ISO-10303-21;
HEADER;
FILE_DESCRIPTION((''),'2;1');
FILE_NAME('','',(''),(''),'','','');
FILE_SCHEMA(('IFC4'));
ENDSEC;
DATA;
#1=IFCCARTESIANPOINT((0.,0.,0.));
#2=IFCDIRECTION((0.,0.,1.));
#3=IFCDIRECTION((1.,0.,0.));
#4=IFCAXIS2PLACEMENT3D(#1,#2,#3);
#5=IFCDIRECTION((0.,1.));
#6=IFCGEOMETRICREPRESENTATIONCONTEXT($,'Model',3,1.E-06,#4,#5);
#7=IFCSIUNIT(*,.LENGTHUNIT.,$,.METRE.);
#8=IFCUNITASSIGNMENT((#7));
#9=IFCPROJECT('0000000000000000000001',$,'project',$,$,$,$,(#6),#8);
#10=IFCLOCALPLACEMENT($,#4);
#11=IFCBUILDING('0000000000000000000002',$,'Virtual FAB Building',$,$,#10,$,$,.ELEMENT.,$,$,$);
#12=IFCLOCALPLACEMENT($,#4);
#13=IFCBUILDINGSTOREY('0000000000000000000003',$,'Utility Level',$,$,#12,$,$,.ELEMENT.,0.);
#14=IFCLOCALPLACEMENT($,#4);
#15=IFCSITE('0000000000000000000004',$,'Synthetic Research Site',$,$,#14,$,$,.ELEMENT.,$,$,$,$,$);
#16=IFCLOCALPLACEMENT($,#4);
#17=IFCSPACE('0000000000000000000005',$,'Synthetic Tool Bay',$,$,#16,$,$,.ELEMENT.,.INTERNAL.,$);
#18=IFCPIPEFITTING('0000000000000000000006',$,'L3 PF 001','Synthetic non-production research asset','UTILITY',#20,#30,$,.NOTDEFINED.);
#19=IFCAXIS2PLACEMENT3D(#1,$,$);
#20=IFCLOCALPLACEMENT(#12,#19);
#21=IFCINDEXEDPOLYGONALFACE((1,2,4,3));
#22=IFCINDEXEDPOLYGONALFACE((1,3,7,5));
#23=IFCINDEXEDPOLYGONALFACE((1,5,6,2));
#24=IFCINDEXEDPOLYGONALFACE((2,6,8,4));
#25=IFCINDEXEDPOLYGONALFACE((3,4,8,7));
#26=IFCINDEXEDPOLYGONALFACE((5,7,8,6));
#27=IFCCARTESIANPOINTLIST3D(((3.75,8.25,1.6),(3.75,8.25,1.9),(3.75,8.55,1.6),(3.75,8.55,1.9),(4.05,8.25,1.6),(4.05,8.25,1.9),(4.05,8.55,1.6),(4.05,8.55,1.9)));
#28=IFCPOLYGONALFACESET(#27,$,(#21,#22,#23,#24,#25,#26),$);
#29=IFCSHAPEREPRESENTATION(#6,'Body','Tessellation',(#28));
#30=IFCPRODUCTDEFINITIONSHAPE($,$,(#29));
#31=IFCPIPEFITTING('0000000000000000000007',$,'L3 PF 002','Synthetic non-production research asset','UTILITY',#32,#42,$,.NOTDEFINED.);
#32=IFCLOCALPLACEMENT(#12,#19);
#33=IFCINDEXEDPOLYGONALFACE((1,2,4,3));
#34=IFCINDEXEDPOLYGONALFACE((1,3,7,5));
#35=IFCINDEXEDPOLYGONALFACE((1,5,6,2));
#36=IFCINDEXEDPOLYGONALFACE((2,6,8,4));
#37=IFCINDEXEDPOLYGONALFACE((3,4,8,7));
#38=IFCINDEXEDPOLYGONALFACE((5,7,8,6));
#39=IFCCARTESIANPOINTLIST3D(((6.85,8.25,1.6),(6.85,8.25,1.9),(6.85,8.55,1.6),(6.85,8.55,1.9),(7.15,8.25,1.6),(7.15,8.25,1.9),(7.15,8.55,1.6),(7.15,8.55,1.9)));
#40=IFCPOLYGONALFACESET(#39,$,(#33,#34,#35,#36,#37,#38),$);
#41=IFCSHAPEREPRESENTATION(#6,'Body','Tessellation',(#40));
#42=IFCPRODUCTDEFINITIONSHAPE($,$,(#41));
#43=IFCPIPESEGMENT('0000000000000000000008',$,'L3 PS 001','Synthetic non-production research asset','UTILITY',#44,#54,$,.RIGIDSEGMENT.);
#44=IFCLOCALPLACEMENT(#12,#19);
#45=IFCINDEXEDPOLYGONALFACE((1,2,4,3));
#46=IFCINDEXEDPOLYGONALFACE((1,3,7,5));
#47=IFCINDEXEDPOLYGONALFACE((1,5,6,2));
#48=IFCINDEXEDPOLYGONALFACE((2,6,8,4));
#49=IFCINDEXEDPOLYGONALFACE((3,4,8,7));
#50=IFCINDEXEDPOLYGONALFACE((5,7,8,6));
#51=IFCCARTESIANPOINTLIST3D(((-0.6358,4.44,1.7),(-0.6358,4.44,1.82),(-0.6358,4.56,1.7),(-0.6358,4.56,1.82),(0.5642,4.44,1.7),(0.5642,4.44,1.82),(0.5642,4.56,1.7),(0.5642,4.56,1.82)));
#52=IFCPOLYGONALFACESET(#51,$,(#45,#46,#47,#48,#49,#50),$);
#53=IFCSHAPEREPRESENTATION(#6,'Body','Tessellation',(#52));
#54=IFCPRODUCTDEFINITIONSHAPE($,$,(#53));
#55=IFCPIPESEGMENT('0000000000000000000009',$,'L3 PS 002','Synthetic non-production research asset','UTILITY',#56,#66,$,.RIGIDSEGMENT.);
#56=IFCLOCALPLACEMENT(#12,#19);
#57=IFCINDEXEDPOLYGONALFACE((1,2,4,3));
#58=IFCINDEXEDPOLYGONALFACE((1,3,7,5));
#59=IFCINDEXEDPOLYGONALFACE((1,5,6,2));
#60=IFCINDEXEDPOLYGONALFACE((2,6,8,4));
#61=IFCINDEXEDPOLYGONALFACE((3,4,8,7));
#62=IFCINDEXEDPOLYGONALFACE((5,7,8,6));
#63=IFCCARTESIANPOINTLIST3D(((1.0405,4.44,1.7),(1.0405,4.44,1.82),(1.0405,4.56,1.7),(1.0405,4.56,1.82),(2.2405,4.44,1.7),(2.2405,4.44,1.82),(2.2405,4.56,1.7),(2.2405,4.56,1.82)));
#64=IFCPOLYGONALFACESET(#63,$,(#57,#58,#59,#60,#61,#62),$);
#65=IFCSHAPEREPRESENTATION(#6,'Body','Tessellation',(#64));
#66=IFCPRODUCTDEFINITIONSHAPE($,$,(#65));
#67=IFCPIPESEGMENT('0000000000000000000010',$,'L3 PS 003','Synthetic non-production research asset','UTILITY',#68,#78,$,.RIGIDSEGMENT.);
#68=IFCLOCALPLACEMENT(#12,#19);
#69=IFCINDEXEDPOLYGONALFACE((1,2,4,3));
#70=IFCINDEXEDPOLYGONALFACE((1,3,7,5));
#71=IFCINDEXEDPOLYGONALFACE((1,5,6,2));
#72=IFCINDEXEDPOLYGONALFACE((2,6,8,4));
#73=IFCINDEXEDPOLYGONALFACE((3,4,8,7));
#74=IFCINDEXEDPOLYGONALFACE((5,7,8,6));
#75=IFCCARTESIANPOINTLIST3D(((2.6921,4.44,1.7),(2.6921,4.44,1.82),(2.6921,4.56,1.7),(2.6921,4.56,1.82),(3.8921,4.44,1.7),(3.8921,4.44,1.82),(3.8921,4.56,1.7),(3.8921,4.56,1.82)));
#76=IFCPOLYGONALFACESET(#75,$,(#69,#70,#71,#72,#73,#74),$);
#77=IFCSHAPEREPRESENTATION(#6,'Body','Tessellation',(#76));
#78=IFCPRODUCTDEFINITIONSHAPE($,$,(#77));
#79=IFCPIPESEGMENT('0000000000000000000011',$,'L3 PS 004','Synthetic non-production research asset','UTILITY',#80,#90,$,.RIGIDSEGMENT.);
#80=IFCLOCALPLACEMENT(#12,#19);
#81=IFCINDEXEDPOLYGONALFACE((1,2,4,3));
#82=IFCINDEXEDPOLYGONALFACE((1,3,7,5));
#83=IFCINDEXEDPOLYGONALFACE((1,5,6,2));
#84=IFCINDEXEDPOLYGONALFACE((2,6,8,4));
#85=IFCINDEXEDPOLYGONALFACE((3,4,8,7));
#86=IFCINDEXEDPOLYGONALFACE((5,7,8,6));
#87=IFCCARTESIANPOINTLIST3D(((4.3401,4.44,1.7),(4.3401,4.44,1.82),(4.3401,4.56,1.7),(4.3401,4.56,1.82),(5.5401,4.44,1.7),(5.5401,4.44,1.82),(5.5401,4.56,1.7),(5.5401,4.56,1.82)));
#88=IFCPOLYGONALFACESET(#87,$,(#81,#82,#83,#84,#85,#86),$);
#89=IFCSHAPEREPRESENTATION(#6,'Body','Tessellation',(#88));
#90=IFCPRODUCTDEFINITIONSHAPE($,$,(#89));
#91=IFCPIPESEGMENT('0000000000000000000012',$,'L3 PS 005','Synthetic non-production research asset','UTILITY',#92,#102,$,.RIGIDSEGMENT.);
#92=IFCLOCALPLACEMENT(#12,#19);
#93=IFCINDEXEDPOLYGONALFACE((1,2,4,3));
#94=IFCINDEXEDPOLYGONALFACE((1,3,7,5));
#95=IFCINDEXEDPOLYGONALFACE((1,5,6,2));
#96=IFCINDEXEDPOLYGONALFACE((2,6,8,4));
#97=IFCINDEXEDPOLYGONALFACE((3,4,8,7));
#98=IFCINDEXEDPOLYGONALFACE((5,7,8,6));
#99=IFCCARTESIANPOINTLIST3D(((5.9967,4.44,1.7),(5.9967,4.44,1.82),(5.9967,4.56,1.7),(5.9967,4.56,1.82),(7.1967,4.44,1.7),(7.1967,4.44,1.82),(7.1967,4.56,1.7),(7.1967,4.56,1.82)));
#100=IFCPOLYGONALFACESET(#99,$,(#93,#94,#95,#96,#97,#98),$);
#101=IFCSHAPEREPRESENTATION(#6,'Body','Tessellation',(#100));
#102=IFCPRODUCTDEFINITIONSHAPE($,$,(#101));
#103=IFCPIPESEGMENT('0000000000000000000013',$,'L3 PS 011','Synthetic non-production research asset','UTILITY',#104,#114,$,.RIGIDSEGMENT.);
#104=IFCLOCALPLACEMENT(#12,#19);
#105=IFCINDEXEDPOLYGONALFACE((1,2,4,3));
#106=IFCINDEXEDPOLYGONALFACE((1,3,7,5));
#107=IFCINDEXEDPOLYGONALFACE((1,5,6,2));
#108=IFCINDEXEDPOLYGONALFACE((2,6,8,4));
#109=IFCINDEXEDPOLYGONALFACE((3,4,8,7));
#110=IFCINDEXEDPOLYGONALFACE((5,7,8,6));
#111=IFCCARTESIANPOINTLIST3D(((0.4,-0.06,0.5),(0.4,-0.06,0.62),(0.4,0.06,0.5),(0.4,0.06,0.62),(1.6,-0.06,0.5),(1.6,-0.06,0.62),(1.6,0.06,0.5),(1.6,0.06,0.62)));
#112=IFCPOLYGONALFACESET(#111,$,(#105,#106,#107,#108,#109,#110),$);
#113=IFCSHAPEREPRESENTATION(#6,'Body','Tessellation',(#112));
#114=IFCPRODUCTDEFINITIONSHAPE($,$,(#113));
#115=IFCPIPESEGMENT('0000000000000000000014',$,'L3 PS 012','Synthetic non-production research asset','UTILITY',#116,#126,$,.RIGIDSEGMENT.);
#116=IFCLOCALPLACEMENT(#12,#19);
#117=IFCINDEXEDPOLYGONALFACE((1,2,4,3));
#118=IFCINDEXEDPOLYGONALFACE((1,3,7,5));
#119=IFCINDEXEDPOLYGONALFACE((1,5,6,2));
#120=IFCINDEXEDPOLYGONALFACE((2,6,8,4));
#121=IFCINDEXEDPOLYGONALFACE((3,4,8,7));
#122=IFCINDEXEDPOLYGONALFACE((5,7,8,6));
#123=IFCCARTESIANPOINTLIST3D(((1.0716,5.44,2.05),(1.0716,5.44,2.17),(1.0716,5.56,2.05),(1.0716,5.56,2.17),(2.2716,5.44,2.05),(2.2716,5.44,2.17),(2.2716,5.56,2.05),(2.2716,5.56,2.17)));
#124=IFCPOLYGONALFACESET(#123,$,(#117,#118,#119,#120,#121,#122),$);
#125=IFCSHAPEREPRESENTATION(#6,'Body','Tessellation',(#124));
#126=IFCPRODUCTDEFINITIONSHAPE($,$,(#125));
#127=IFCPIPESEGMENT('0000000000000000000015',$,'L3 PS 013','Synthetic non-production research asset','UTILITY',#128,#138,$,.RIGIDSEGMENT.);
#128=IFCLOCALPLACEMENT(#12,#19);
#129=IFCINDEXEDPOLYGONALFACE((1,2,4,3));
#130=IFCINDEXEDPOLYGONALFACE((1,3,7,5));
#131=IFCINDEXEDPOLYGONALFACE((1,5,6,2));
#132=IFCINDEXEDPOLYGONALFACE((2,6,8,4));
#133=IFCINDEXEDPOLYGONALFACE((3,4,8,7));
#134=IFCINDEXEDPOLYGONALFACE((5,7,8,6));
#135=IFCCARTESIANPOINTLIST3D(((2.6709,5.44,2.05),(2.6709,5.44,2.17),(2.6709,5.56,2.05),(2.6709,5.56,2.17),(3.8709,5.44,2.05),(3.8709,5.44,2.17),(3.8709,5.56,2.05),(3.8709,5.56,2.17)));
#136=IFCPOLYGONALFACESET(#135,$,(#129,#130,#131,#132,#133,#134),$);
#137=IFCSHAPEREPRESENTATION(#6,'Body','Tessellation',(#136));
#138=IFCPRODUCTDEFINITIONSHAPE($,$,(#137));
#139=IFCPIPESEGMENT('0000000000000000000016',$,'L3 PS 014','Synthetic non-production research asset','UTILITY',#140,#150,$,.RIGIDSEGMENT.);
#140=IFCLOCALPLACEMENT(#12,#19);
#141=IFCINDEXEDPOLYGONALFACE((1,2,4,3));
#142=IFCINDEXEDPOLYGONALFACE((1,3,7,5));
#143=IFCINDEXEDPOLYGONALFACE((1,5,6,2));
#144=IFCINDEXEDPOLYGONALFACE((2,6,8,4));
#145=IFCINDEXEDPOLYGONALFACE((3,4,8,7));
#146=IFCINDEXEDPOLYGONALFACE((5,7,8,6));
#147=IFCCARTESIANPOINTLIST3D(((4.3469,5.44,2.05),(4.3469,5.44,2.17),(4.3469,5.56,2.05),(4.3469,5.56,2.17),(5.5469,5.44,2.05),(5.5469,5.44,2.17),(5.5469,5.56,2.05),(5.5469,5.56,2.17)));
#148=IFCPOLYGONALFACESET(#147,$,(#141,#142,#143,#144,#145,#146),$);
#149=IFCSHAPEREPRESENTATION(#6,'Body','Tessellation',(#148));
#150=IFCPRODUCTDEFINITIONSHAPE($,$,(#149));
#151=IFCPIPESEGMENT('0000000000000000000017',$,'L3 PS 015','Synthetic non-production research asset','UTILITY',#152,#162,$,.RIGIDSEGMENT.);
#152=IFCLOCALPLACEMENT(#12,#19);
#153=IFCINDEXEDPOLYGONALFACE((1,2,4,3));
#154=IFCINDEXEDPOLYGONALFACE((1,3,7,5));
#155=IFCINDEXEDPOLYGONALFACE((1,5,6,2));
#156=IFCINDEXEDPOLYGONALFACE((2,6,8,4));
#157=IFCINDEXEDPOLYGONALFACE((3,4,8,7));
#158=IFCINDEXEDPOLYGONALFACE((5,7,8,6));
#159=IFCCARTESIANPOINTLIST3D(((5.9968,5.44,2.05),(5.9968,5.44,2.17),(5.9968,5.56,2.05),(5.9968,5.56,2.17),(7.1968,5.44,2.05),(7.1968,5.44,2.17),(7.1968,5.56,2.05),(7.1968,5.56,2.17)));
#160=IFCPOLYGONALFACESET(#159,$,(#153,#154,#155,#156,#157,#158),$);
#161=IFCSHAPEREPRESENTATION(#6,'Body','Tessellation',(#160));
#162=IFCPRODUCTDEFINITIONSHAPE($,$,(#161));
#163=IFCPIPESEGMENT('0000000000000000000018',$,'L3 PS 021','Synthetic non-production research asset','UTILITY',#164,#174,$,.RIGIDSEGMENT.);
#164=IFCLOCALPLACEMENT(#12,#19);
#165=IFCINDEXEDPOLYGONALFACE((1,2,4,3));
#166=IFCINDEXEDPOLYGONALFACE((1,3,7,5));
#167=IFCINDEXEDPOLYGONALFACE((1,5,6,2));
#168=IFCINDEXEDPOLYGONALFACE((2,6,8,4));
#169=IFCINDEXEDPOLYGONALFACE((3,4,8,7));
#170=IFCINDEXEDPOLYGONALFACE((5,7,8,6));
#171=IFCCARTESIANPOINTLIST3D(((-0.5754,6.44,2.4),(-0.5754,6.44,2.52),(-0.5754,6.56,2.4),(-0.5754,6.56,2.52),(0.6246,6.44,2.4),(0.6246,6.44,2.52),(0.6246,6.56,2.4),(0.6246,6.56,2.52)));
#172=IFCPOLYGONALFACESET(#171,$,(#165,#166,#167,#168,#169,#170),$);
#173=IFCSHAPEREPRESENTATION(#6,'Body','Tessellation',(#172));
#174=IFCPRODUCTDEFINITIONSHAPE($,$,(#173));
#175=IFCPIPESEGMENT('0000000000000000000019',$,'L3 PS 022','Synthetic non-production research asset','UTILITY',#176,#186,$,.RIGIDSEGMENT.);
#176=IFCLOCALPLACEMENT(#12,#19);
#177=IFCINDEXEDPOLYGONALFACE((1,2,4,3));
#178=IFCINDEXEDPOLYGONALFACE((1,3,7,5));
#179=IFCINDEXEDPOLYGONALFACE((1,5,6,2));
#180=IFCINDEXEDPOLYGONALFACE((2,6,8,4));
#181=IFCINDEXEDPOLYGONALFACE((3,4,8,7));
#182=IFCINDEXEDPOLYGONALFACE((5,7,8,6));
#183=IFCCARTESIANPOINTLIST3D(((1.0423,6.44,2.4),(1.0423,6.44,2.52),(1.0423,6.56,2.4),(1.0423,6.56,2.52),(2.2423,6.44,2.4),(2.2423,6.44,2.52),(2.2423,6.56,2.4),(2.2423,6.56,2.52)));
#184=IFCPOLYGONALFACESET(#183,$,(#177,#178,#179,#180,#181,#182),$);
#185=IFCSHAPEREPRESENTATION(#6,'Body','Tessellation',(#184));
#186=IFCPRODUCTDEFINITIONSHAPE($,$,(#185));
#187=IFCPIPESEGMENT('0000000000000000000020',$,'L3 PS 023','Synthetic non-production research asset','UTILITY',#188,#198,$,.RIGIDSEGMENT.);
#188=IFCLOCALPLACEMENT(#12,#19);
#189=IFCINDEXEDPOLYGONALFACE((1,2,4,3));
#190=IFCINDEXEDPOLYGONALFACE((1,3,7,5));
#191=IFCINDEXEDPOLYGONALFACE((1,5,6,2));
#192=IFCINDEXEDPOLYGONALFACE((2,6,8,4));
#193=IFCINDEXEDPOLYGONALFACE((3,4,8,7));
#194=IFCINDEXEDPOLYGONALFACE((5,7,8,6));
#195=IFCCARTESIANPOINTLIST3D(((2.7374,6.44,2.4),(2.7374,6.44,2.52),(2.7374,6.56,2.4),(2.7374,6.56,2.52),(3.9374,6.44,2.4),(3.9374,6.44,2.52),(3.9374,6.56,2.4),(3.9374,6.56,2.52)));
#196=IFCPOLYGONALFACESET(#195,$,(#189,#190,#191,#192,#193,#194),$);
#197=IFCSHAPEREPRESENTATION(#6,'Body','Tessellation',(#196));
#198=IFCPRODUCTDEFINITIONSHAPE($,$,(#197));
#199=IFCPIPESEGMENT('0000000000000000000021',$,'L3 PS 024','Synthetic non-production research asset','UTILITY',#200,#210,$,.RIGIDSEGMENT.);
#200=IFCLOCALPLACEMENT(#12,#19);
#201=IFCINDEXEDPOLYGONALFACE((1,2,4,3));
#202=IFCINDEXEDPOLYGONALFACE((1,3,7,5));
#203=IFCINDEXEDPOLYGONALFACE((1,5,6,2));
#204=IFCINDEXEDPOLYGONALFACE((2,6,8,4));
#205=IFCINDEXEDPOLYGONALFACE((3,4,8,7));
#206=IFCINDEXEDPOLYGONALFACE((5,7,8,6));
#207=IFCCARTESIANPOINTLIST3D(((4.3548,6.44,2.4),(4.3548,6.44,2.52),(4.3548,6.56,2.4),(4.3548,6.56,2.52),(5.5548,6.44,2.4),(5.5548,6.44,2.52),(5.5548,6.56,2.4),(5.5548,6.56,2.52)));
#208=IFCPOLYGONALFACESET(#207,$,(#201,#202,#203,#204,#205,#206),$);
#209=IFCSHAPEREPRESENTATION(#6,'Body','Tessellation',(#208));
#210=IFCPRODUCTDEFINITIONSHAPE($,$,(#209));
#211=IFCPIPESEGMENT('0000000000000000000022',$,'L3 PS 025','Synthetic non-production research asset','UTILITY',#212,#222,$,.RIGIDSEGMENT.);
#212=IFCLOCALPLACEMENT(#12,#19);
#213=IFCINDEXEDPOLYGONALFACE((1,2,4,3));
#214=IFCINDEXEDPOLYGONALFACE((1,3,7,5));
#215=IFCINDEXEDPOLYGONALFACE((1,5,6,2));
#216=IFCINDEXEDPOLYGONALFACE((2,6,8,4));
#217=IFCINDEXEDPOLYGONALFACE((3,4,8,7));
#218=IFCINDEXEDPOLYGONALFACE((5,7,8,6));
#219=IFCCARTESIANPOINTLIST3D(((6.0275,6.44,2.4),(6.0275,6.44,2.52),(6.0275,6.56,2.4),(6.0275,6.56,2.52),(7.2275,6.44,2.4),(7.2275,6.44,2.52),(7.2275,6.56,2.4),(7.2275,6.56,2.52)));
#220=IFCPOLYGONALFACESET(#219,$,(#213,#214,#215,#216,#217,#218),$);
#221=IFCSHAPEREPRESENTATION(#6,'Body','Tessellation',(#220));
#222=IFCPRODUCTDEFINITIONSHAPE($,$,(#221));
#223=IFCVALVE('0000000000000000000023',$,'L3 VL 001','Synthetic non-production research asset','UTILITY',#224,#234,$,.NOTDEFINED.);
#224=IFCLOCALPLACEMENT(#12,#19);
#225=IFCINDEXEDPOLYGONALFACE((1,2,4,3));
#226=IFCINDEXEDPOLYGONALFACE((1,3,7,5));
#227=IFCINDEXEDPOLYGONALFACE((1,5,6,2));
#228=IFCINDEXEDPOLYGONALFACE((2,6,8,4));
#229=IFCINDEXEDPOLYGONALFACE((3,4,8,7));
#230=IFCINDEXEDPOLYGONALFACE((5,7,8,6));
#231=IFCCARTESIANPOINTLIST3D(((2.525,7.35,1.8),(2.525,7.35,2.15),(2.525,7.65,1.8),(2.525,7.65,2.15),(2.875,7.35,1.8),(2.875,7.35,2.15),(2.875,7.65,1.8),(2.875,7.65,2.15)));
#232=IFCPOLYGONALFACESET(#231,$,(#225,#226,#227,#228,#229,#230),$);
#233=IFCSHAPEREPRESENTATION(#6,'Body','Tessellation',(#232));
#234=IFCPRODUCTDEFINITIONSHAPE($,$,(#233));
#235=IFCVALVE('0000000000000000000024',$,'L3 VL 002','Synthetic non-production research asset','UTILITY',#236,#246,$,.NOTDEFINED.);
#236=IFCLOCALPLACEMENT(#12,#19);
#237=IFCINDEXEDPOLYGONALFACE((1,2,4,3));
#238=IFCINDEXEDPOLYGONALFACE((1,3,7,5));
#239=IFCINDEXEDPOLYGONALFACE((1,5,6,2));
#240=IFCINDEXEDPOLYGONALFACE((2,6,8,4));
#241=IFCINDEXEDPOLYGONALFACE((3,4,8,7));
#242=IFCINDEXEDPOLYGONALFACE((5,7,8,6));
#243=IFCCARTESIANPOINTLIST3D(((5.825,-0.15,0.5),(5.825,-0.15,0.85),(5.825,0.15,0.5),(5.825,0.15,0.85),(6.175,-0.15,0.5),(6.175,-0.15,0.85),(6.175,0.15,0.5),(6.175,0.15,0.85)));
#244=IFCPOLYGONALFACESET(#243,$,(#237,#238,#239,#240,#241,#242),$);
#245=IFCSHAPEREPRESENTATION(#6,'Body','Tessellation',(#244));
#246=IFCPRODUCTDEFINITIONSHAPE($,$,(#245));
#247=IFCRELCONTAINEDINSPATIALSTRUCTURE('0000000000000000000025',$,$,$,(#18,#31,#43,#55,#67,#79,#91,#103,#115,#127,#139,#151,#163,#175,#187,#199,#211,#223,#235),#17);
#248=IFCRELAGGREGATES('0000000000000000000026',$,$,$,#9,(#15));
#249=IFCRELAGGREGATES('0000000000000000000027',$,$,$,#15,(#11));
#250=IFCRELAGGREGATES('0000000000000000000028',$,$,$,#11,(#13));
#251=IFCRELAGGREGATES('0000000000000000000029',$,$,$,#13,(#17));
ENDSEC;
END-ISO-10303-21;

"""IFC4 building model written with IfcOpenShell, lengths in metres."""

from ifc_helpers import new_model, si_unit, direction, frame, origin_with_axes, origin_2d_with_axis, place, context, project, spatial, rectangle, extrude, element, save


model = new_model("IFC4")

# Units and contexts
model_context = context("Model", 3, precision=1e-06, world=origin_with_axes(), true_north=direction((0.0, 1.0)))
ifc_project = project(units=[si_unit("LENGTHUNIT", "METRE")], contexts=[model_context])

# Site, building, storey, space
site_placement = place(None, origin_with_axes())
site = spatial("IfcSite", under=ifc_project, at=site_placement, Name="Synthetic Research Site", CompositionType="ELEMENT")
building_placement = place(None, origin_with_axes())
building = spatial("IfcBuilding", under=site, at=building_placement, Name="Virtual FAB Building", CompositionType="ELEMENT")
storey_placement = place(None, origin_with_axes())
storey = spatial("IfcBuildingStorey", under=building, at=storey_placement, Name="Utility Level", CompositionType="ELEMENT", Elevation=0.0)
space_placement = place(None, origin_with_axes())
space = spatial("IfcSpace", under=storey, at=space_placement, Name="Synthetic Tool Bay", CompositionType="ELEMENT", PredefinedType="INTERNAL")

# Pipe fittings
for number, where, z_axis, x_axis, name in (
    (1, (3.9, 8.4, 1.6), (0.0, 0.0, 1.0), (1.0, 0.0, 0.0), "L3 PF 001"),
    (2, (7.0, 8.4, 1.6), (0.0, 0.0, 1.0), (1.0, 0.0, 0.0), "L3 PF 002"),
):
    element("IfcPipeFitting", number, at=place(None, frame(where, z_axis=z_axis, x_axis=x_axis)), inside=space, Name=name, Description="Synthetic non-production research asset", ObjectType="UTILITY", PredefinedType="NOTDEFINED", context=model_context, shape_type="SweptSolid", body=[
        extrude(rectangle(XDim=0.3, YDim=0.3, at=origin_2d_with_axis()), origin_with_axes(), (0.0, 0.0, 1.0), 0.3),
    ])

# Pipe segments
for number, where, z_axis, x_axis, name in (
    (3, (-0.0358, 4.5, 1.7), (0.0, 0.0, 1.0), (1.0, 0.0, 0.0), "L3 PS 001"),
    (4, (1.6405, 4.5, 1.7), (0.0, 0.0, 1.0), (1.0, 0.0, 0.0), "L3 PS 002"),
    (5, (3.2921, 4.5, 1.7), (0.0, 0.0, 1.0), (1.0, 0.0, 0.0), "L3 PS 003"),
    (6, (4.9401, 4.5, 1.7), (0.0, 0.0, 1.0), (1.0, 0.0, 0.0), "L3 PS 004"),
    (7, (6.5967, 4.5, 1.7), (0.0, 0.0, 1.0), (1.0, 0.0, 0.0), "L3 PS 005"),
    (8, (1.0, 0.0, 0.5), (0.0, 0.0, 1.0), (1.0, 0.0, 0.0), "L3 PS 011"),
    (9, (1.6716, 5.5, 2.05), (0.0, 0.0, 1.0), (1.0, 0.0, 0.0), "L3 PS 012"),
    (10, (3.2709, 5.5, 2.05), (0.0, 0.0, 1.0), (1.0, 0.0, 0.0), "L3 PS 013"),
    (11, (4.9469, 5.5, 2.05), (0.0, 0.0, 1.0), (1.0, 0.0, 0.0), "L3 PS 014"),
    (12, (6.5968, 5.5, 2.05), (0.0, 0.0, 1.0), (1.0, 0.0, 0.0), "L3 PS 015"),
    (13, (0.0246, 6.5, 2.4), (0.0, 0.0, 1.0), (1.0, 0.0, 0.0), "L3 PS 021"),
    (14, (1.6423, 6.5, 2.4), (0.0, 0.0, 1.0), (1.0, 0.0, 0.0), "L3 PS 022"),
    (15, (3.3374, 6.5, 2.4), (0.0, 0.0, 1.0), (1.0, 0.0, 0.0), "L3 PS 023"),
    (16, (4.9548, 6.5, 2.4), (0.0, 0.0, 1.0), (1.0, 0.0, 0.0), "L3 PS 024"),
    (17, (6.6275, 6.5, 2.4), (0.0, 0.0, 1.0), (1.0, 0.0, 0.0), "L3 PS 025"),
):
    element("IfcPipeSegment", number, at=place(None, frame(where, z_axis=z_axis, x_axis=x_axis)), inside=space, Name=name, Description="Synthetic non-production research asset", ObjectType="UTILITY", PredefinedType="RIGIDSEGMENT", context=model_context, shape_type="SweptSolid", body=[
        extrude(rectangle(XDim=1.2, YDim=0.12, at=origin_2d_with_axis()), origin_with_axes(), (0.0, 0.0, 1.0), 0.12),
    ])

# Valves
for number, where, z_axis, x_axis, name in (
    (18, (2.7, 7.5, 1.8), (0.0, 0.0, 1.0), (1.0, 0.0, 0.0), "L3 VL 001"),
    (19, (6.0, 0.0, 0.5), (0.0, 0.0, 1.0), (1.0, 0.0, 0.0), "L3 VL 002"),
):
    element("IfcValve", number, at=place(None, frame(where, z_axis=z_axis, x_axis=x_axis)), inside=space, Name=name, Description="Synthetic non-production research asset", ObjectType="UTILITY", PredefinedType="NOTDEFINED", context=model_context, shape_type="SweptSolid", body=[
        extrude(rectangle(XDim=0.35, YDim=0.3, at=origin_2d_with_axis()), origin_with_axes(), (0.0, 0.0, 1.0), 0.35),
    ])

save(model, "model.ifc")
